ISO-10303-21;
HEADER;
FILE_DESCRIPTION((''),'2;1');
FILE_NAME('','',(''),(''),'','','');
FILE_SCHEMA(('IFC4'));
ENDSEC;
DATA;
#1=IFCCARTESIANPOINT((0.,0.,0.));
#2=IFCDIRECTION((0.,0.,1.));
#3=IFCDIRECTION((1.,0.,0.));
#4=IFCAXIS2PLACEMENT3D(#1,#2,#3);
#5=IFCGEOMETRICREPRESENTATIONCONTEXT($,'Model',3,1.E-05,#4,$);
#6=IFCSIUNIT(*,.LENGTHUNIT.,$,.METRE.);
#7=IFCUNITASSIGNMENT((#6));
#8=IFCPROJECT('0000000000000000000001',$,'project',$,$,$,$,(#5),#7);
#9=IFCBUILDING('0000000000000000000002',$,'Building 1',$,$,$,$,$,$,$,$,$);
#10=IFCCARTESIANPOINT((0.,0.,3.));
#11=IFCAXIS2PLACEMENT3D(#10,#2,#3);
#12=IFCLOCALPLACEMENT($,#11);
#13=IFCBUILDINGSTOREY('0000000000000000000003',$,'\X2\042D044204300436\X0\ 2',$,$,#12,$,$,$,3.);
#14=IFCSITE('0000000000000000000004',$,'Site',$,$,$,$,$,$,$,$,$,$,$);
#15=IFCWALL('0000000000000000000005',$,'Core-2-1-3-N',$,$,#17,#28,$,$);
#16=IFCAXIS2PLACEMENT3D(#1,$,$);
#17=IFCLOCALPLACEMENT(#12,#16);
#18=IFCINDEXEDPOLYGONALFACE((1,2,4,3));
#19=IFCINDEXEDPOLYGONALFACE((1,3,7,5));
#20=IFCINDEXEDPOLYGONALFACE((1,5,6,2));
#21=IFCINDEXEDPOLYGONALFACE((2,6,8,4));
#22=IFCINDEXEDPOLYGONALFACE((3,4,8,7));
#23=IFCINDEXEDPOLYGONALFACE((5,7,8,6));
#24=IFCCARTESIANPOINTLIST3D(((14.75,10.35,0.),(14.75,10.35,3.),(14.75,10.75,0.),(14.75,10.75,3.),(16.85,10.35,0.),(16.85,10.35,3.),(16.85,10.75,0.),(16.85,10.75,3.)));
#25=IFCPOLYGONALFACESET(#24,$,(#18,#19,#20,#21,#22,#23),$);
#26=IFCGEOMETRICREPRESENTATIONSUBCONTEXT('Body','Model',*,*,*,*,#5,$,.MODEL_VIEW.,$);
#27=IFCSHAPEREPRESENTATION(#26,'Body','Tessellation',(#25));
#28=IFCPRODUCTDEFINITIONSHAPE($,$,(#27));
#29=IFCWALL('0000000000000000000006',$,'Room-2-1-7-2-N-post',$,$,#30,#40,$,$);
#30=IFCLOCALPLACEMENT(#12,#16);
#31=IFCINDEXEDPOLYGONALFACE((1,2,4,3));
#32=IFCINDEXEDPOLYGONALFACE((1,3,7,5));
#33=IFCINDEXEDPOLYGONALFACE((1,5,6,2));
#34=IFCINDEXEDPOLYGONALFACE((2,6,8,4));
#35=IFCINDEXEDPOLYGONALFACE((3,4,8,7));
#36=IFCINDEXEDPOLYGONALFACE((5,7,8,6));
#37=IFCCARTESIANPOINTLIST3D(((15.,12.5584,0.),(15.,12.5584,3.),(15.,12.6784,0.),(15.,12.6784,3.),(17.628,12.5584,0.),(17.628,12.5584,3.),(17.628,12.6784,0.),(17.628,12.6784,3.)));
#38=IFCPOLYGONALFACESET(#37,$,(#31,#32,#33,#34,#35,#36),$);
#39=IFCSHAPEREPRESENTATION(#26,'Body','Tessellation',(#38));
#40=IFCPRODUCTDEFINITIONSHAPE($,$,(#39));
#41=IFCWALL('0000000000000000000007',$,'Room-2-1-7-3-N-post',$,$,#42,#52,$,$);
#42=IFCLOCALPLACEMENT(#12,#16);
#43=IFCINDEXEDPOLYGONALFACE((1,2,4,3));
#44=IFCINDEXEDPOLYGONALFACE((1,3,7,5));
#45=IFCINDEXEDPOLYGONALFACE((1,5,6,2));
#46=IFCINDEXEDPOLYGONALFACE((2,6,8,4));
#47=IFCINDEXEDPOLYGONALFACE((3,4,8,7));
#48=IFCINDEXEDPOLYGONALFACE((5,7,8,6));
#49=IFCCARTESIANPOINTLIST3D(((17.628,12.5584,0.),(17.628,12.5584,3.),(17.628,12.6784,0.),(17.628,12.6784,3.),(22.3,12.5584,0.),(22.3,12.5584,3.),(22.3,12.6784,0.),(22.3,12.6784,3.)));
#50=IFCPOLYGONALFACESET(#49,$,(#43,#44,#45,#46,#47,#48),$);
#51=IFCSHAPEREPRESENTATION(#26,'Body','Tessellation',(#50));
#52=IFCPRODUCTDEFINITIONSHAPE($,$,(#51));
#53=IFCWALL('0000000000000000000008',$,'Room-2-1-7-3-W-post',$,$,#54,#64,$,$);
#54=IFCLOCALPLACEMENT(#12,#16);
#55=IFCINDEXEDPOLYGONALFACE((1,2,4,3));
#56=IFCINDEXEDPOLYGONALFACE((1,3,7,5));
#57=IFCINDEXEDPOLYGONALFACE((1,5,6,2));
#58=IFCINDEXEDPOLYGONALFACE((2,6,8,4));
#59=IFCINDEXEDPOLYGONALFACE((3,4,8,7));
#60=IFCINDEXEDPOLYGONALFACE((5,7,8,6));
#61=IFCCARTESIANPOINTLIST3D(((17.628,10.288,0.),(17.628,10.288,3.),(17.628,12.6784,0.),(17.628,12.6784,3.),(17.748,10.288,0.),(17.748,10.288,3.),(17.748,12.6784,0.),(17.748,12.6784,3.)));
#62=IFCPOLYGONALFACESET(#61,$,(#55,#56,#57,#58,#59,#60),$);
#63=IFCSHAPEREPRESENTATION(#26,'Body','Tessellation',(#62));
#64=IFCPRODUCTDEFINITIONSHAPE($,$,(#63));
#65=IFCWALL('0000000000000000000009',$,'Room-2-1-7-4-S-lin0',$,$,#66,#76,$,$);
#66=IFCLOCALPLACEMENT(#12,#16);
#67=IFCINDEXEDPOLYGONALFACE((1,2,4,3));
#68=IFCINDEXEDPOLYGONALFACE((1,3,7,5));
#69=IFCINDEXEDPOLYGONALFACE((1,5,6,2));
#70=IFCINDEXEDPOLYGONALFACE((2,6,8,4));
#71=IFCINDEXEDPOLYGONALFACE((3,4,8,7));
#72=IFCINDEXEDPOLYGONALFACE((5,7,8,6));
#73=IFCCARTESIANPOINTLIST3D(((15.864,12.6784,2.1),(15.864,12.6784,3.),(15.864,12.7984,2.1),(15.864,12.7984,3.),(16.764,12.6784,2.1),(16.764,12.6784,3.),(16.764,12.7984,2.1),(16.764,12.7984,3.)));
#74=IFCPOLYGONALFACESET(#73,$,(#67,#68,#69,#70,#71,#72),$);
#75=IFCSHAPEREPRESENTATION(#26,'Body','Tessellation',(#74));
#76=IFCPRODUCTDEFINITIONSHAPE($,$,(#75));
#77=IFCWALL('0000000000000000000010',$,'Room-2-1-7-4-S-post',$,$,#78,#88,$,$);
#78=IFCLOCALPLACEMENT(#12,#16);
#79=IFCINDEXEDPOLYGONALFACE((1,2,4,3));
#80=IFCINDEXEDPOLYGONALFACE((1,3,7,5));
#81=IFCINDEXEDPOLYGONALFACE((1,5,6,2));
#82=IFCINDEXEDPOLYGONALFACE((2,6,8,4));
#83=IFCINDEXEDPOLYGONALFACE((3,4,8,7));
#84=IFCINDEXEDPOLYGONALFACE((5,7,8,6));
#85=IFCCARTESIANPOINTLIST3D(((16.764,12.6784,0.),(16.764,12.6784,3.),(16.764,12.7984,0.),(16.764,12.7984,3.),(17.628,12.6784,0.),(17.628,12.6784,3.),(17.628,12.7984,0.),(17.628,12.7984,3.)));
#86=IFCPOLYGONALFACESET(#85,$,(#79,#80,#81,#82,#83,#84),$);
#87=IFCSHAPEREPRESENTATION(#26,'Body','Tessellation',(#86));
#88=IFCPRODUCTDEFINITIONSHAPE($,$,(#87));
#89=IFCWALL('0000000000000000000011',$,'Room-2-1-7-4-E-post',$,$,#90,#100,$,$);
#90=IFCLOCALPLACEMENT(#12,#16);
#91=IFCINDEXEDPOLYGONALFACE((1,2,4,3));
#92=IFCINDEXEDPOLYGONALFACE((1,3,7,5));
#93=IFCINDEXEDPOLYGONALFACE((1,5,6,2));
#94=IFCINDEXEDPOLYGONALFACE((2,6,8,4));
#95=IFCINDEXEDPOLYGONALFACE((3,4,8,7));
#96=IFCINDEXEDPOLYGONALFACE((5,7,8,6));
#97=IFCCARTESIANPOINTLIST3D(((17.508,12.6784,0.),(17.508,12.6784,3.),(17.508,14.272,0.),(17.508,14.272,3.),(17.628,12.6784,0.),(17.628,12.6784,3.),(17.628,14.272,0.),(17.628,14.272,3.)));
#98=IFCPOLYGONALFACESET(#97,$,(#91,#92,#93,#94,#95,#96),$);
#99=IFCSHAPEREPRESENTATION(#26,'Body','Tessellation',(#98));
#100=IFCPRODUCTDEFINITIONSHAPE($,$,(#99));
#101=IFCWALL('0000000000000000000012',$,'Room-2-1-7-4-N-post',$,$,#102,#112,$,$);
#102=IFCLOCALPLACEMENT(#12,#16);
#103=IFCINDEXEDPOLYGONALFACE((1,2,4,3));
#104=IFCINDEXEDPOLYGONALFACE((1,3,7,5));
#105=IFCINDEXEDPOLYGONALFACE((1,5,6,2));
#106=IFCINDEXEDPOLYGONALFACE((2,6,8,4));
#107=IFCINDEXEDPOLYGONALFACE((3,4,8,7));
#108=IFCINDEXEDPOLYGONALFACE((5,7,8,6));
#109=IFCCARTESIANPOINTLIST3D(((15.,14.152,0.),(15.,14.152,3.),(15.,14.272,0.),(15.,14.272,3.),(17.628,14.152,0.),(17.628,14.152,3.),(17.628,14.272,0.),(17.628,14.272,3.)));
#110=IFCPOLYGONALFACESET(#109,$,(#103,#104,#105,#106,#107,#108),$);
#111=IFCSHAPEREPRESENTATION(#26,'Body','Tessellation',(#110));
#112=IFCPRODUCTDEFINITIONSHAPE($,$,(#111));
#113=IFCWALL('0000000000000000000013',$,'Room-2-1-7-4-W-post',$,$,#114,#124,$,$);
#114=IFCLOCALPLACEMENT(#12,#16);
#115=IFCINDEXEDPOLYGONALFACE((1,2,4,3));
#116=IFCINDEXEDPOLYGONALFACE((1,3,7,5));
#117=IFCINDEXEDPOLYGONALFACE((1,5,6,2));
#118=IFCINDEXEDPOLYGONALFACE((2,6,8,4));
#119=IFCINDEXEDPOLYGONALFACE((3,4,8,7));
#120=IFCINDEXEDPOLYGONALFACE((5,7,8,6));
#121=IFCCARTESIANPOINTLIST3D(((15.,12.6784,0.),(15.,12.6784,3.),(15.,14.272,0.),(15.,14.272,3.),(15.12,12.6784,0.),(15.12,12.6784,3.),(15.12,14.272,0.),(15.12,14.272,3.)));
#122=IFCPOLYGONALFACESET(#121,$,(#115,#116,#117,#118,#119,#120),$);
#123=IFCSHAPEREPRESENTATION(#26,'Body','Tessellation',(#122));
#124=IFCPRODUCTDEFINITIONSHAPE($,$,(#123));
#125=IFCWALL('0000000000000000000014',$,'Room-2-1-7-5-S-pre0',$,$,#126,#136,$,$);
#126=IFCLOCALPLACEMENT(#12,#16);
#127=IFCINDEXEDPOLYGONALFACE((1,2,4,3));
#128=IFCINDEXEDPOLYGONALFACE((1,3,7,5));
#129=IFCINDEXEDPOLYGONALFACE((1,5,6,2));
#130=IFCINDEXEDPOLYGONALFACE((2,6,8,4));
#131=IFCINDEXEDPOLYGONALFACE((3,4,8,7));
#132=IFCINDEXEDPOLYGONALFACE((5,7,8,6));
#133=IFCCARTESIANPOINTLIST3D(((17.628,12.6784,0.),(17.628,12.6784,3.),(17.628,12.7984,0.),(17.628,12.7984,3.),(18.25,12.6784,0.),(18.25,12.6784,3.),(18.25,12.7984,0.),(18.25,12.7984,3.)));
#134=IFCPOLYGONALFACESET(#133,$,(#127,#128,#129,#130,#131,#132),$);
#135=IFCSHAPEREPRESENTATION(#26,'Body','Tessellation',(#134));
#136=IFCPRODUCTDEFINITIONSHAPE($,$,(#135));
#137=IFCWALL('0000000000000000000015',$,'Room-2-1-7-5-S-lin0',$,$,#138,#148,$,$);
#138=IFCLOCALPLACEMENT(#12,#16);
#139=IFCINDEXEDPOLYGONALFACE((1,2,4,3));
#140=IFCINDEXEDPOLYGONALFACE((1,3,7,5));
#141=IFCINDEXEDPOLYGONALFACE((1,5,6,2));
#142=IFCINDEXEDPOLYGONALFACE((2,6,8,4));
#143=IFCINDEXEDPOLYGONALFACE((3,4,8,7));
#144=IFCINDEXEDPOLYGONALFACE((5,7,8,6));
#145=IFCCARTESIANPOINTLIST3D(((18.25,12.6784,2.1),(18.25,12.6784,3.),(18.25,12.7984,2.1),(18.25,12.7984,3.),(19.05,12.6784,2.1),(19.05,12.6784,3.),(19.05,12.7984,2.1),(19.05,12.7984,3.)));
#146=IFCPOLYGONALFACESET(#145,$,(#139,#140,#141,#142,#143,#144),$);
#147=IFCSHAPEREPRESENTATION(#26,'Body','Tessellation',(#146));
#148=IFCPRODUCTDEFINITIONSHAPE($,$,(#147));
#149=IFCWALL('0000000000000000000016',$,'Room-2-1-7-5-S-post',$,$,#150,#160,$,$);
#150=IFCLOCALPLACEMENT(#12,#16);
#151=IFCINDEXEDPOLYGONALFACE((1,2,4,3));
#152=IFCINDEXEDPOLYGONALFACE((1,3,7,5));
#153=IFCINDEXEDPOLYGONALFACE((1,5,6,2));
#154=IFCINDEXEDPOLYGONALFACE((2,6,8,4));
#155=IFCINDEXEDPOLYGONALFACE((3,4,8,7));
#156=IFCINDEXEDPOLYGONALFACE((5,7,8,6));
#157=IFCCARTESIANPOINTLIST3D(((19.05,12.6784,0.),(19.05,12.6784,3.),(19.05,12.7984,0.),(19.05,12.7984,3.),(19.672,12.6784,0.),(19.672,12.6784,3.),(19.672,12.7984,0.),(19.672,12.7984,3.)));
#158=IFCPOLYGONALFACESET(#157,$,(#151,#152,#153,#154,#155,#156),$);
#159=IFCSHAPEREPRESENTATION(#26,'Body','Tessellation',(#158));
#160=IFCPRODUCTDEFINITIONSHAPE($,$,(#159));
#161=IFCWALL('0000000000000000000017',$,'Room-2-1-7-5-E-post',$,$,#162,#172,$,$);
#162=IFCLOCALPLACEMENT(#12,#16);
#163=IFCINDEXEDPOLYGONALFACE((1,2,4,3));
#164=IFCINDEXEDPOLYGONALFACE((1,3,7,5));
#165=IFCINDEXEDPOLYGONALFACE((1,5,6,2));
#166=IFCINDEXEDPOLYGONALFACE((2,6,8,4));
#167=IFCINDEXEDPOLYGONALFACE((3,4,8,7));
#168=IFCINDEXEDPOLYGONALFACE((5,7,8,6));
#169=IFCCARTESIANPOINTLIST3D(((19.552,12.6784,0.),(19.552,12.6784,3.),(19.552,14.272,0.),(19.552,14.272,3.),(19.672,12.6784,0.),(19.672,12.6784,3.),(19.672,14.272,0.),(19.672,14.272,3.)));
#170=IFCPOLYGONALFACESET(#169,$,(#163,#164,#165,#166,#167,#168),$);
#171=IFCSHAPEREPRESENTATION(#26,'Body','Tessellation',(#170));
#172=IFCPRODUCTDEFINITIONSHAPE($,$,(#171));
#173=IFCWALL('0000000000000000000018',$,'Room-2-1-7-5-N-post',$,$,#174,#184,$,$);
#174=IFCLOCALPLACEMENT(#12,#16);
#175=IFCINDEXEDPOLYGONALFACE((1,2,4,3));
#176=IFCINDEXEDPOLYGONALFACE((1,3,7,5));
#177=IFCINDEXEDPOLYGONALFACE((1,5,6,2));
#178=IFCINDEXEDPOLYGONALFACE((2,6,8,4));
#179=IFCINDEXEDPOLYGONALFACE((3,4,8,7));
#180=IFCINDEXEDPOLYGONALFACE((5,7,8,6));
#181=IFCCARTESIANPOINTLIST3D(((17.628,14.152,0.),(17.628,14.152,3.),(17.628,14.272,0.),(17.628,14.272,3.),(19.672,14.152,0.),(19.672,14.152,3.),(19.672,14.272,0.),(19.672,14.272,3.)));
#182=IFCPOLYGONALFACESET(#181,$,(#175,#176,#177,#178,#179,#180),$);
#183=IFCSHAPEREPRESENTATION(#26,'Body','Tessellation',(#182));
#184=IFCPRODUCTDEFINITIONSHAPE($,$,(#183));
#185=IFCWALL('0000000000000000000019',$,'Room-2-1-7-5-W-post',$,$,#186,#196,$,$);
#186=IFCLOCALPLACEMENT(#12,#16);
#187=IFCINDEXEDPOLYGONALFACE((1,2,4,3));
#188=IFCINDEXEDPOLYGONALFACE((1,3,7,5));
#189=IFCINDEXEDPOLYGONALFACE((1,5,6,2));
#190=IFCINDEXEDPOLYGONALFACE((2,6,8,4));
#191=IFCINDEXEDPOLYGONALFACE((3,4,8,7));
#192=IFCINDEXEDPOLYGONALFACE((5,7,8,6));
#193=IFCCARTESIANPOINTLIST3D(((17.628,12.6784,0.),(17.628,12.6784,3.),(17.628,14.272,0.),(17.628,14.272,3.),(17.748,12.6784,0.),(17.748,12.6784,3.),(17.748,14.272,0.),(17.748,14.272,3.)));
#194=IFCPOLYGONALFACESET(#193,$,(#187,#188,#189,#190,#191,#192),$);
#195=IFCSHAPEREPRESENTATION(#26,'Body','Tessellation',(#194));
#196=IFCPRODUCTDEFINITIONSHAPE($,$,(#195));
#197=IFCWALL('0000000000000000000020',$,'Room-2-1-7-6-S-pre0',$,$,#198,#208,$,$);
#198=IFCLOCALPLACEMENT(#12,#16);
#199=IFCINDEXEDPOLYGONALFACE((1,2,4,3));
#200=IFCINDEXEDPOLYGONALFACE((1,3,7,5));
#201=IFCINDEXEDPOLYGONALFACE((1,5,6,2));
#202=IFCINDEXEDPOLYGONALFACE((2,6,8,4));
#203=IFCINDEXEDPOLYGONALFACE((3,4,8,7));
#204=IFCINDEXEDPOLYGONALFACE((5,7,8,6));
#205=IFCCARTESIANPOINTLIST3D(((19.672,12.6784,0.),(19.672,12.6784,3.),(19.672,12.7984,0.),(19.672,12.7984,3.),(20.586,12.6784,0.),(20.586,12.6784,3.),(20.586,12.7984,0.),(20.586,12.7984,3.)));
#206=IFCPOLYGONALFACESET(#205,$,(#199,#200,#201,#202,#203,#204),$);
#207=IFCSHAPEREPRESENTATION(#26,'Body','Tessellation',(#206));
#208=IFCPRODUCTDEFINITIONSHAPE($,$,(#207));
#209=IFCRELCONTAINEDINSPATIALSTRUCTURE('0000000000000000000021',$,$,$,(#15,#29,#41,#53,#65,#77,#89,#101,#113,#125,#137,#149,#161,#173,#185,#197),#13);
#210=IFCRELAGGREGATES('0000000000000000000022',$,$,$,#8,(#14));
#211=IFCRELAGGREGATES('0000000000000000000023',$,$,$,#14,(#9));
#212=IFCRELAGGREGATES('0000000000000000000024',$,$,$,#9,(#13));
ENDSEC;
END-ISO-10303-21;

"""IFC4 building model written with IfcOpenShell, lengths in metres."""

from ifc_helpers import new_model, si_unit, frame, origin_with_axes, place, context, subcontext, project, spatial, indexed_curve, outline, extrude, element, save


model = new_model("IFC4")

# Units and contexts
model_context = context("Model", 3, precision=1e-05, world=origin_with_axes())
body_context = subcontext(model_context, "Body", "Model", "MODEL_VIEW")
ifc_project = project(units=[si_unit("LENGTHUNIT", "METRE")], contexts=[model_context])

# Site, building, storey
site = spatial("IfcSite", under=ifc_project, Name="Site")
building = spatial("IfcBuilding", under=site, Name="Building 1")
storey_placement = place(None, frame((0.0, 0.0, 3.0), z_axis=(0.0, 0.0, 1.0), x_axis=(1.0, 0.0, 0.0)))
storey = spatial("IfcBuildingStorey", under=building, at=storey_placement, Name="Этаж 2", Elevation=3.0)

# Walls
wall_1_placement = place(storey_placement, frame((16.85, 10.75, 0.0), z_axis=(0.0, 0.0, 1.0), x_axis=(-1.0, 0.0, 0.0)))
element("IfcWall", 1, at=wall_1_placement, inside=storey, Name="Core-2-1-3-N", context=body_context, shape_type="SweptSolid", body=[
    extrude(outline(indexed_curve([(0.0, 0.0), (0.0, 0.4), (2.1, 0.4), (2.1, 0.0), (0.0, 0.0)], self_intersect=False)), origin_with_axes(), (0.0, 0.0, 1.0), 3.0),
])
wall_2_placement = place(storey_placement, frame((17.628, 12.6784, 0.0), z_axis=(0.0, 0.0, 1.0), x_axis=(-1.0, 0.0, 0.0)))
element("IfcWall", 2, at=wall_2_placement, inside=storey, Name="Room-2-1-7-2-N-post", context=body_context, shape_type="SweptSolid", body=[
    extrude(outline(indexed_curve([(0.0, 0.0), (0.0, 0.12), (2.628, 0.12), (2.628, 0.0), (0.0, 0.0)], self_intersect=False)), origin_with_axes(), (0.0, 0.0, 1.0), 3.0),
])
wall_3_placement = place(storey_placement, frame((22.3, 12.6784, 0.0), z_axis=(0.0, 0.0, 1.0), x_axis=(-1.0, 0.0, 0.0)))
element("IfcWall", 3, at=wall_3_placement, inside=storey, Name="Room-2-1-7-3-N-post", context=body_context, shape_type="SweptSolid", body=[
    extrude(outline(indexed_curve([(0.0, 0.0), (0.0, 0.12), (4.672, 0.12), (4.672, 0.0), (0.0, 0.0)], self_intersect=False)), origin_with_axes(), (0.0, 0.0, 1.0), 3.0),
])
wall_4_placement = place(storey_placement, frame((17.628, 12.6784, 0.0), z_axis=(0.0, 0.0, 1.0), x_axis=(0.0, -1.0, 0.0)))
element("IfcWall", 4, at=wall_4_placement, inside=storey, Name="Room-2-1-7-3-W-post", context=body_context, shape_type="SweptSolid", body=[
    extrude(outline(indexed_curve([(0.0, 0.0), (0.0, 0.12), (2.3904, 0.12), (2.3904, 0.0), (0.0, 0.0)], self_intersect=False)), origin_with_axes(), (0.0, 0.0, 1.0), 3.0),
])
wall_5_placement = place(storey_placement, frame((15.864, 12.6784, 2.1), z_axis=(0.0, 0.0, 1.0), x_axis=(1.0, 0.0, 0.0)))
element("IfcWall", 5, at=wall_5_placement, inside=storey, Name="Room-2-1-7-4-S-lin0", context=body_context, shape_type="SweptSolid", body=[
    extrude(outline(indexed_curve([(0.0, 0.0), (0.0, 0.12), (0.9, 0.12), (0.9, 0.0), (0.0, 0.0)], self_intersect=False)), origin_with_axes(), (0.0, 0.0, 1.0), 0.9),
])
wall_6_placement = place(storey_placement, frame((16.764, 12.6784, 0.0), z_axis=(0.0, 0.0, 1.0), x_axis=(1.0, 0.0, 0.0)))
element("IfcWall", 6, at=wall_6_placement, inside=storey, Name="Room-2-1-7-4-S-post", context=body_context, shape_type="SweptSolid", body=[
    extrude(outline(indexed_curve([(0.0, 0.0), (0.0, 0.12), (0.864, 0.12), (0.864, 0.0), (0.0, 0.0)], self_intersect=False)), origin_with_axes(), (0.0, 0.0, 1.0), 3.0),
])
wall_7_placement = place(storey_placement, frame((17.628, 12.6784, 0.0), z_axis=(0.0, 0.0, 1.0), x_axis=(0.0, 1.0, 0.0)))
element("IfcWall", 7, at=wall_7_placement, inside=storey, Name="Room-2-1-7-4-E-post", context=body_context, shape_type="SweptSolid", body=[
    extrude(outline(indexed_curve([(0.0, 0.0), (0.0, 0.12), (1.5936, 0.12), (1.5936, 0.0), (0.0, 0.0)], self_intersect=False)), origin_with_axes(), (0.0, 0.0, 1.0), 3.0),
])
wall_8_placement = place(storey_placement, frame((17.628, 14.272, 0.0), z_axis=(0.0, 0.0, 1.0), x_axis=(-1.0, 0.0, 0.0)))
element("IfcWall", 8, at=wall_8_placement, inside=storey, Name="Room-2-1-7-4-N-post", context=body_context, shape_type="SweptSolid", body=[
    extrude(outline(indexed_curve([(0.0, 0.0), (0.0, 0.12), (2.628, 0.12), (2.628, 0.0), (0.0, 0.0)], self_intersect=False)), origin_with_axes(), (0.0, 0.0, 1.0), 3.0),
])
wall_9_placement = place(storey_placement, frame((15.0, 14.272, 0.0), z_axis=(0.0, 0.0, 1.0), x_axis=(0.0, -1.0, 0.0)))
element("IfcWall", 9, at=wall_9_placement, inside=storey, Name="Room-2-1-7-4-W-post", context=body_context, shape_type="SweptSolid", body=[
    extrude(outline(indexed_curve([(0.0, 0.0), (0.0, 0.12), (1.5936, 0.12), (1.5936, 0.0), (0.0, 0.0)], self_intersect=False)), origin_with_axes(), (0.0, 0.0, 1.0), 3.0),
])
wall_10_placement = place(storey_placement, frame((17.628, 12.6784, 0.0), z_axis=(0.0, 0.0, 1.0), x_axis=(1.0, 0.0, 0.0)))
element("IfcWall", 10, at=wall_10_placement, inside=storey, Name="Room-2-1-7-5-S-pre0", context=body_context, shape_type="SweptSolid", body=[
    extrude(outline(indexed_curve([(0.0, 0.0), (0.0, 0.12), (0.622, 0.12), (0.622, 0.0), (0.0, 0.0)], self_intersect=False)), origin_with_axes(), (0.0, 0.0, 1.0), 3.0),
])
wall_11_placement = place(storey_placement, frame((18.25, 12.6784, 2.1), z_axis=(0.0, 0.0, 1.0), x_axis=(1.0, 0.0, 0.0)))
element("IfcWall", 11, at=wall_11_placement, inside=storey, Name="Room-2-1-7-5-S-lin0", context=body_context, shape_type="SweptSolid", body=[
    extrude(outline(indexed_curve([(0.0, 0.0), (0.0, 0.12), (0.8, 0.12), (0.8, 0.0), (0.0, 0.0)], self_intersect=False)), origin_with_axes(), (0.0, 0.0, 1.0), 0.9),
])
wall_12_placement = place(storey_placement, frame((19.05, 12.6784, 0.0), z_axis=(0.0, 0.0, 1.0), x_axis=(1.0, 0.0, 0.0)))
element("IfcWall", 12, at=wall_12_placement, inside=storey, Name="Room-2-1-7-5-S-post", context=body_context, shape_type="SweptSolid", body=[
    extrude(outline(indexed_curve([(0.0, 0.0), (0.0, 0.12), (0.622, 0.12), (0.622, 0.0), (0.0, 0.0)], self_intersect=False)), origin_with_axes(), (0.0, 0.0, 1.0), 3.0),
])
wall_13_placement = place(storey_placement, frame((19.672, 12.6784, 0.0), z_axis=(0.0, 0.0, 1.0), x_axis=(0.0, 1.0, 0.0)))
element("IfcWall", 13, at=wall_13_placement, inside=storey, Name="Room-2-1-7-5-E-post", context=body_context, shape_type="SweptSolid", body=[
    extrude(outline(indexed_curve([(0.0, 0.0), (0.0, 0.12), (1.5936, 0.12), (1.5936, 0.0), (0.0, 0.0)], self_intersect=False)), origin_with_axes(), (0.0, 0.0, 1.0), 3.0),
])
wall_14_placement = place(storey_placement, frame((19.672, 14.272, 0.0), z_axis=(0.0, 0.0, 1.0), x_axis=(-1.0, 0.0, 0.0)))
element("IfcWall", 14, at=wall_14_placement, inside=storey, Name="Room-2-1-7-5-N-post", context=body_context, shape_type="SweptSolid", body=[
    extrude(outline(indexed_curve([(0.0, 0.0), (0.0, 0.12), (2.044, 0.12), (2.044, 0.0), (0.0, 0.0)], self_intersect=False)), origin_with_axes(), (0.0, 0.0, 1.0), 3.0),
])
wall_15_placement = place(storey_placement, frame((17.628, 14.272, 0.0), z_axis=(0.0, 0.0, 1.0), x_axis=(0.0, -1.0, 0.0)))
element("IfcWall", 15, at=wall_15_placement, inside=storey, Name="Room-2-1-7-5-W-post", context=body_context, shape_type="SweptSolid", body=[
    extrude(outline(indexed_curve([(0.0, 0.0), (0.0, 0.12), (1.5936, 0.12), (1.5936, 0.0), (0.0, 0.0)], self_intersect=False)), origin_with_axes(), (0.0, 0.0, 1.0), 3.0),
])
wall_16_placement = place(storey_placement, frame((19.672, 12.6784, 0.0), z_axis=(0.0, 0.0, 1.0), x_axis=(1.0, 0.0, 0.0)))
element("IfcWall", 16, at=wall_16_placement, inside=storey, Name="Room-2-1-7-6-S-pre0", context=body_context, shape_type="SweptSolid", body=[
    extrude(outline(indexed_curve([(0.0, 0.0), (0.0, 0.12), (0.914, 0.12), (0.914, 0.0), (0.0, 0.0)], self_intersect=False)), origin_with_axes(), (0.0, 0.0, 1.0), 3.0),
])

save(model, "model.ifc")
